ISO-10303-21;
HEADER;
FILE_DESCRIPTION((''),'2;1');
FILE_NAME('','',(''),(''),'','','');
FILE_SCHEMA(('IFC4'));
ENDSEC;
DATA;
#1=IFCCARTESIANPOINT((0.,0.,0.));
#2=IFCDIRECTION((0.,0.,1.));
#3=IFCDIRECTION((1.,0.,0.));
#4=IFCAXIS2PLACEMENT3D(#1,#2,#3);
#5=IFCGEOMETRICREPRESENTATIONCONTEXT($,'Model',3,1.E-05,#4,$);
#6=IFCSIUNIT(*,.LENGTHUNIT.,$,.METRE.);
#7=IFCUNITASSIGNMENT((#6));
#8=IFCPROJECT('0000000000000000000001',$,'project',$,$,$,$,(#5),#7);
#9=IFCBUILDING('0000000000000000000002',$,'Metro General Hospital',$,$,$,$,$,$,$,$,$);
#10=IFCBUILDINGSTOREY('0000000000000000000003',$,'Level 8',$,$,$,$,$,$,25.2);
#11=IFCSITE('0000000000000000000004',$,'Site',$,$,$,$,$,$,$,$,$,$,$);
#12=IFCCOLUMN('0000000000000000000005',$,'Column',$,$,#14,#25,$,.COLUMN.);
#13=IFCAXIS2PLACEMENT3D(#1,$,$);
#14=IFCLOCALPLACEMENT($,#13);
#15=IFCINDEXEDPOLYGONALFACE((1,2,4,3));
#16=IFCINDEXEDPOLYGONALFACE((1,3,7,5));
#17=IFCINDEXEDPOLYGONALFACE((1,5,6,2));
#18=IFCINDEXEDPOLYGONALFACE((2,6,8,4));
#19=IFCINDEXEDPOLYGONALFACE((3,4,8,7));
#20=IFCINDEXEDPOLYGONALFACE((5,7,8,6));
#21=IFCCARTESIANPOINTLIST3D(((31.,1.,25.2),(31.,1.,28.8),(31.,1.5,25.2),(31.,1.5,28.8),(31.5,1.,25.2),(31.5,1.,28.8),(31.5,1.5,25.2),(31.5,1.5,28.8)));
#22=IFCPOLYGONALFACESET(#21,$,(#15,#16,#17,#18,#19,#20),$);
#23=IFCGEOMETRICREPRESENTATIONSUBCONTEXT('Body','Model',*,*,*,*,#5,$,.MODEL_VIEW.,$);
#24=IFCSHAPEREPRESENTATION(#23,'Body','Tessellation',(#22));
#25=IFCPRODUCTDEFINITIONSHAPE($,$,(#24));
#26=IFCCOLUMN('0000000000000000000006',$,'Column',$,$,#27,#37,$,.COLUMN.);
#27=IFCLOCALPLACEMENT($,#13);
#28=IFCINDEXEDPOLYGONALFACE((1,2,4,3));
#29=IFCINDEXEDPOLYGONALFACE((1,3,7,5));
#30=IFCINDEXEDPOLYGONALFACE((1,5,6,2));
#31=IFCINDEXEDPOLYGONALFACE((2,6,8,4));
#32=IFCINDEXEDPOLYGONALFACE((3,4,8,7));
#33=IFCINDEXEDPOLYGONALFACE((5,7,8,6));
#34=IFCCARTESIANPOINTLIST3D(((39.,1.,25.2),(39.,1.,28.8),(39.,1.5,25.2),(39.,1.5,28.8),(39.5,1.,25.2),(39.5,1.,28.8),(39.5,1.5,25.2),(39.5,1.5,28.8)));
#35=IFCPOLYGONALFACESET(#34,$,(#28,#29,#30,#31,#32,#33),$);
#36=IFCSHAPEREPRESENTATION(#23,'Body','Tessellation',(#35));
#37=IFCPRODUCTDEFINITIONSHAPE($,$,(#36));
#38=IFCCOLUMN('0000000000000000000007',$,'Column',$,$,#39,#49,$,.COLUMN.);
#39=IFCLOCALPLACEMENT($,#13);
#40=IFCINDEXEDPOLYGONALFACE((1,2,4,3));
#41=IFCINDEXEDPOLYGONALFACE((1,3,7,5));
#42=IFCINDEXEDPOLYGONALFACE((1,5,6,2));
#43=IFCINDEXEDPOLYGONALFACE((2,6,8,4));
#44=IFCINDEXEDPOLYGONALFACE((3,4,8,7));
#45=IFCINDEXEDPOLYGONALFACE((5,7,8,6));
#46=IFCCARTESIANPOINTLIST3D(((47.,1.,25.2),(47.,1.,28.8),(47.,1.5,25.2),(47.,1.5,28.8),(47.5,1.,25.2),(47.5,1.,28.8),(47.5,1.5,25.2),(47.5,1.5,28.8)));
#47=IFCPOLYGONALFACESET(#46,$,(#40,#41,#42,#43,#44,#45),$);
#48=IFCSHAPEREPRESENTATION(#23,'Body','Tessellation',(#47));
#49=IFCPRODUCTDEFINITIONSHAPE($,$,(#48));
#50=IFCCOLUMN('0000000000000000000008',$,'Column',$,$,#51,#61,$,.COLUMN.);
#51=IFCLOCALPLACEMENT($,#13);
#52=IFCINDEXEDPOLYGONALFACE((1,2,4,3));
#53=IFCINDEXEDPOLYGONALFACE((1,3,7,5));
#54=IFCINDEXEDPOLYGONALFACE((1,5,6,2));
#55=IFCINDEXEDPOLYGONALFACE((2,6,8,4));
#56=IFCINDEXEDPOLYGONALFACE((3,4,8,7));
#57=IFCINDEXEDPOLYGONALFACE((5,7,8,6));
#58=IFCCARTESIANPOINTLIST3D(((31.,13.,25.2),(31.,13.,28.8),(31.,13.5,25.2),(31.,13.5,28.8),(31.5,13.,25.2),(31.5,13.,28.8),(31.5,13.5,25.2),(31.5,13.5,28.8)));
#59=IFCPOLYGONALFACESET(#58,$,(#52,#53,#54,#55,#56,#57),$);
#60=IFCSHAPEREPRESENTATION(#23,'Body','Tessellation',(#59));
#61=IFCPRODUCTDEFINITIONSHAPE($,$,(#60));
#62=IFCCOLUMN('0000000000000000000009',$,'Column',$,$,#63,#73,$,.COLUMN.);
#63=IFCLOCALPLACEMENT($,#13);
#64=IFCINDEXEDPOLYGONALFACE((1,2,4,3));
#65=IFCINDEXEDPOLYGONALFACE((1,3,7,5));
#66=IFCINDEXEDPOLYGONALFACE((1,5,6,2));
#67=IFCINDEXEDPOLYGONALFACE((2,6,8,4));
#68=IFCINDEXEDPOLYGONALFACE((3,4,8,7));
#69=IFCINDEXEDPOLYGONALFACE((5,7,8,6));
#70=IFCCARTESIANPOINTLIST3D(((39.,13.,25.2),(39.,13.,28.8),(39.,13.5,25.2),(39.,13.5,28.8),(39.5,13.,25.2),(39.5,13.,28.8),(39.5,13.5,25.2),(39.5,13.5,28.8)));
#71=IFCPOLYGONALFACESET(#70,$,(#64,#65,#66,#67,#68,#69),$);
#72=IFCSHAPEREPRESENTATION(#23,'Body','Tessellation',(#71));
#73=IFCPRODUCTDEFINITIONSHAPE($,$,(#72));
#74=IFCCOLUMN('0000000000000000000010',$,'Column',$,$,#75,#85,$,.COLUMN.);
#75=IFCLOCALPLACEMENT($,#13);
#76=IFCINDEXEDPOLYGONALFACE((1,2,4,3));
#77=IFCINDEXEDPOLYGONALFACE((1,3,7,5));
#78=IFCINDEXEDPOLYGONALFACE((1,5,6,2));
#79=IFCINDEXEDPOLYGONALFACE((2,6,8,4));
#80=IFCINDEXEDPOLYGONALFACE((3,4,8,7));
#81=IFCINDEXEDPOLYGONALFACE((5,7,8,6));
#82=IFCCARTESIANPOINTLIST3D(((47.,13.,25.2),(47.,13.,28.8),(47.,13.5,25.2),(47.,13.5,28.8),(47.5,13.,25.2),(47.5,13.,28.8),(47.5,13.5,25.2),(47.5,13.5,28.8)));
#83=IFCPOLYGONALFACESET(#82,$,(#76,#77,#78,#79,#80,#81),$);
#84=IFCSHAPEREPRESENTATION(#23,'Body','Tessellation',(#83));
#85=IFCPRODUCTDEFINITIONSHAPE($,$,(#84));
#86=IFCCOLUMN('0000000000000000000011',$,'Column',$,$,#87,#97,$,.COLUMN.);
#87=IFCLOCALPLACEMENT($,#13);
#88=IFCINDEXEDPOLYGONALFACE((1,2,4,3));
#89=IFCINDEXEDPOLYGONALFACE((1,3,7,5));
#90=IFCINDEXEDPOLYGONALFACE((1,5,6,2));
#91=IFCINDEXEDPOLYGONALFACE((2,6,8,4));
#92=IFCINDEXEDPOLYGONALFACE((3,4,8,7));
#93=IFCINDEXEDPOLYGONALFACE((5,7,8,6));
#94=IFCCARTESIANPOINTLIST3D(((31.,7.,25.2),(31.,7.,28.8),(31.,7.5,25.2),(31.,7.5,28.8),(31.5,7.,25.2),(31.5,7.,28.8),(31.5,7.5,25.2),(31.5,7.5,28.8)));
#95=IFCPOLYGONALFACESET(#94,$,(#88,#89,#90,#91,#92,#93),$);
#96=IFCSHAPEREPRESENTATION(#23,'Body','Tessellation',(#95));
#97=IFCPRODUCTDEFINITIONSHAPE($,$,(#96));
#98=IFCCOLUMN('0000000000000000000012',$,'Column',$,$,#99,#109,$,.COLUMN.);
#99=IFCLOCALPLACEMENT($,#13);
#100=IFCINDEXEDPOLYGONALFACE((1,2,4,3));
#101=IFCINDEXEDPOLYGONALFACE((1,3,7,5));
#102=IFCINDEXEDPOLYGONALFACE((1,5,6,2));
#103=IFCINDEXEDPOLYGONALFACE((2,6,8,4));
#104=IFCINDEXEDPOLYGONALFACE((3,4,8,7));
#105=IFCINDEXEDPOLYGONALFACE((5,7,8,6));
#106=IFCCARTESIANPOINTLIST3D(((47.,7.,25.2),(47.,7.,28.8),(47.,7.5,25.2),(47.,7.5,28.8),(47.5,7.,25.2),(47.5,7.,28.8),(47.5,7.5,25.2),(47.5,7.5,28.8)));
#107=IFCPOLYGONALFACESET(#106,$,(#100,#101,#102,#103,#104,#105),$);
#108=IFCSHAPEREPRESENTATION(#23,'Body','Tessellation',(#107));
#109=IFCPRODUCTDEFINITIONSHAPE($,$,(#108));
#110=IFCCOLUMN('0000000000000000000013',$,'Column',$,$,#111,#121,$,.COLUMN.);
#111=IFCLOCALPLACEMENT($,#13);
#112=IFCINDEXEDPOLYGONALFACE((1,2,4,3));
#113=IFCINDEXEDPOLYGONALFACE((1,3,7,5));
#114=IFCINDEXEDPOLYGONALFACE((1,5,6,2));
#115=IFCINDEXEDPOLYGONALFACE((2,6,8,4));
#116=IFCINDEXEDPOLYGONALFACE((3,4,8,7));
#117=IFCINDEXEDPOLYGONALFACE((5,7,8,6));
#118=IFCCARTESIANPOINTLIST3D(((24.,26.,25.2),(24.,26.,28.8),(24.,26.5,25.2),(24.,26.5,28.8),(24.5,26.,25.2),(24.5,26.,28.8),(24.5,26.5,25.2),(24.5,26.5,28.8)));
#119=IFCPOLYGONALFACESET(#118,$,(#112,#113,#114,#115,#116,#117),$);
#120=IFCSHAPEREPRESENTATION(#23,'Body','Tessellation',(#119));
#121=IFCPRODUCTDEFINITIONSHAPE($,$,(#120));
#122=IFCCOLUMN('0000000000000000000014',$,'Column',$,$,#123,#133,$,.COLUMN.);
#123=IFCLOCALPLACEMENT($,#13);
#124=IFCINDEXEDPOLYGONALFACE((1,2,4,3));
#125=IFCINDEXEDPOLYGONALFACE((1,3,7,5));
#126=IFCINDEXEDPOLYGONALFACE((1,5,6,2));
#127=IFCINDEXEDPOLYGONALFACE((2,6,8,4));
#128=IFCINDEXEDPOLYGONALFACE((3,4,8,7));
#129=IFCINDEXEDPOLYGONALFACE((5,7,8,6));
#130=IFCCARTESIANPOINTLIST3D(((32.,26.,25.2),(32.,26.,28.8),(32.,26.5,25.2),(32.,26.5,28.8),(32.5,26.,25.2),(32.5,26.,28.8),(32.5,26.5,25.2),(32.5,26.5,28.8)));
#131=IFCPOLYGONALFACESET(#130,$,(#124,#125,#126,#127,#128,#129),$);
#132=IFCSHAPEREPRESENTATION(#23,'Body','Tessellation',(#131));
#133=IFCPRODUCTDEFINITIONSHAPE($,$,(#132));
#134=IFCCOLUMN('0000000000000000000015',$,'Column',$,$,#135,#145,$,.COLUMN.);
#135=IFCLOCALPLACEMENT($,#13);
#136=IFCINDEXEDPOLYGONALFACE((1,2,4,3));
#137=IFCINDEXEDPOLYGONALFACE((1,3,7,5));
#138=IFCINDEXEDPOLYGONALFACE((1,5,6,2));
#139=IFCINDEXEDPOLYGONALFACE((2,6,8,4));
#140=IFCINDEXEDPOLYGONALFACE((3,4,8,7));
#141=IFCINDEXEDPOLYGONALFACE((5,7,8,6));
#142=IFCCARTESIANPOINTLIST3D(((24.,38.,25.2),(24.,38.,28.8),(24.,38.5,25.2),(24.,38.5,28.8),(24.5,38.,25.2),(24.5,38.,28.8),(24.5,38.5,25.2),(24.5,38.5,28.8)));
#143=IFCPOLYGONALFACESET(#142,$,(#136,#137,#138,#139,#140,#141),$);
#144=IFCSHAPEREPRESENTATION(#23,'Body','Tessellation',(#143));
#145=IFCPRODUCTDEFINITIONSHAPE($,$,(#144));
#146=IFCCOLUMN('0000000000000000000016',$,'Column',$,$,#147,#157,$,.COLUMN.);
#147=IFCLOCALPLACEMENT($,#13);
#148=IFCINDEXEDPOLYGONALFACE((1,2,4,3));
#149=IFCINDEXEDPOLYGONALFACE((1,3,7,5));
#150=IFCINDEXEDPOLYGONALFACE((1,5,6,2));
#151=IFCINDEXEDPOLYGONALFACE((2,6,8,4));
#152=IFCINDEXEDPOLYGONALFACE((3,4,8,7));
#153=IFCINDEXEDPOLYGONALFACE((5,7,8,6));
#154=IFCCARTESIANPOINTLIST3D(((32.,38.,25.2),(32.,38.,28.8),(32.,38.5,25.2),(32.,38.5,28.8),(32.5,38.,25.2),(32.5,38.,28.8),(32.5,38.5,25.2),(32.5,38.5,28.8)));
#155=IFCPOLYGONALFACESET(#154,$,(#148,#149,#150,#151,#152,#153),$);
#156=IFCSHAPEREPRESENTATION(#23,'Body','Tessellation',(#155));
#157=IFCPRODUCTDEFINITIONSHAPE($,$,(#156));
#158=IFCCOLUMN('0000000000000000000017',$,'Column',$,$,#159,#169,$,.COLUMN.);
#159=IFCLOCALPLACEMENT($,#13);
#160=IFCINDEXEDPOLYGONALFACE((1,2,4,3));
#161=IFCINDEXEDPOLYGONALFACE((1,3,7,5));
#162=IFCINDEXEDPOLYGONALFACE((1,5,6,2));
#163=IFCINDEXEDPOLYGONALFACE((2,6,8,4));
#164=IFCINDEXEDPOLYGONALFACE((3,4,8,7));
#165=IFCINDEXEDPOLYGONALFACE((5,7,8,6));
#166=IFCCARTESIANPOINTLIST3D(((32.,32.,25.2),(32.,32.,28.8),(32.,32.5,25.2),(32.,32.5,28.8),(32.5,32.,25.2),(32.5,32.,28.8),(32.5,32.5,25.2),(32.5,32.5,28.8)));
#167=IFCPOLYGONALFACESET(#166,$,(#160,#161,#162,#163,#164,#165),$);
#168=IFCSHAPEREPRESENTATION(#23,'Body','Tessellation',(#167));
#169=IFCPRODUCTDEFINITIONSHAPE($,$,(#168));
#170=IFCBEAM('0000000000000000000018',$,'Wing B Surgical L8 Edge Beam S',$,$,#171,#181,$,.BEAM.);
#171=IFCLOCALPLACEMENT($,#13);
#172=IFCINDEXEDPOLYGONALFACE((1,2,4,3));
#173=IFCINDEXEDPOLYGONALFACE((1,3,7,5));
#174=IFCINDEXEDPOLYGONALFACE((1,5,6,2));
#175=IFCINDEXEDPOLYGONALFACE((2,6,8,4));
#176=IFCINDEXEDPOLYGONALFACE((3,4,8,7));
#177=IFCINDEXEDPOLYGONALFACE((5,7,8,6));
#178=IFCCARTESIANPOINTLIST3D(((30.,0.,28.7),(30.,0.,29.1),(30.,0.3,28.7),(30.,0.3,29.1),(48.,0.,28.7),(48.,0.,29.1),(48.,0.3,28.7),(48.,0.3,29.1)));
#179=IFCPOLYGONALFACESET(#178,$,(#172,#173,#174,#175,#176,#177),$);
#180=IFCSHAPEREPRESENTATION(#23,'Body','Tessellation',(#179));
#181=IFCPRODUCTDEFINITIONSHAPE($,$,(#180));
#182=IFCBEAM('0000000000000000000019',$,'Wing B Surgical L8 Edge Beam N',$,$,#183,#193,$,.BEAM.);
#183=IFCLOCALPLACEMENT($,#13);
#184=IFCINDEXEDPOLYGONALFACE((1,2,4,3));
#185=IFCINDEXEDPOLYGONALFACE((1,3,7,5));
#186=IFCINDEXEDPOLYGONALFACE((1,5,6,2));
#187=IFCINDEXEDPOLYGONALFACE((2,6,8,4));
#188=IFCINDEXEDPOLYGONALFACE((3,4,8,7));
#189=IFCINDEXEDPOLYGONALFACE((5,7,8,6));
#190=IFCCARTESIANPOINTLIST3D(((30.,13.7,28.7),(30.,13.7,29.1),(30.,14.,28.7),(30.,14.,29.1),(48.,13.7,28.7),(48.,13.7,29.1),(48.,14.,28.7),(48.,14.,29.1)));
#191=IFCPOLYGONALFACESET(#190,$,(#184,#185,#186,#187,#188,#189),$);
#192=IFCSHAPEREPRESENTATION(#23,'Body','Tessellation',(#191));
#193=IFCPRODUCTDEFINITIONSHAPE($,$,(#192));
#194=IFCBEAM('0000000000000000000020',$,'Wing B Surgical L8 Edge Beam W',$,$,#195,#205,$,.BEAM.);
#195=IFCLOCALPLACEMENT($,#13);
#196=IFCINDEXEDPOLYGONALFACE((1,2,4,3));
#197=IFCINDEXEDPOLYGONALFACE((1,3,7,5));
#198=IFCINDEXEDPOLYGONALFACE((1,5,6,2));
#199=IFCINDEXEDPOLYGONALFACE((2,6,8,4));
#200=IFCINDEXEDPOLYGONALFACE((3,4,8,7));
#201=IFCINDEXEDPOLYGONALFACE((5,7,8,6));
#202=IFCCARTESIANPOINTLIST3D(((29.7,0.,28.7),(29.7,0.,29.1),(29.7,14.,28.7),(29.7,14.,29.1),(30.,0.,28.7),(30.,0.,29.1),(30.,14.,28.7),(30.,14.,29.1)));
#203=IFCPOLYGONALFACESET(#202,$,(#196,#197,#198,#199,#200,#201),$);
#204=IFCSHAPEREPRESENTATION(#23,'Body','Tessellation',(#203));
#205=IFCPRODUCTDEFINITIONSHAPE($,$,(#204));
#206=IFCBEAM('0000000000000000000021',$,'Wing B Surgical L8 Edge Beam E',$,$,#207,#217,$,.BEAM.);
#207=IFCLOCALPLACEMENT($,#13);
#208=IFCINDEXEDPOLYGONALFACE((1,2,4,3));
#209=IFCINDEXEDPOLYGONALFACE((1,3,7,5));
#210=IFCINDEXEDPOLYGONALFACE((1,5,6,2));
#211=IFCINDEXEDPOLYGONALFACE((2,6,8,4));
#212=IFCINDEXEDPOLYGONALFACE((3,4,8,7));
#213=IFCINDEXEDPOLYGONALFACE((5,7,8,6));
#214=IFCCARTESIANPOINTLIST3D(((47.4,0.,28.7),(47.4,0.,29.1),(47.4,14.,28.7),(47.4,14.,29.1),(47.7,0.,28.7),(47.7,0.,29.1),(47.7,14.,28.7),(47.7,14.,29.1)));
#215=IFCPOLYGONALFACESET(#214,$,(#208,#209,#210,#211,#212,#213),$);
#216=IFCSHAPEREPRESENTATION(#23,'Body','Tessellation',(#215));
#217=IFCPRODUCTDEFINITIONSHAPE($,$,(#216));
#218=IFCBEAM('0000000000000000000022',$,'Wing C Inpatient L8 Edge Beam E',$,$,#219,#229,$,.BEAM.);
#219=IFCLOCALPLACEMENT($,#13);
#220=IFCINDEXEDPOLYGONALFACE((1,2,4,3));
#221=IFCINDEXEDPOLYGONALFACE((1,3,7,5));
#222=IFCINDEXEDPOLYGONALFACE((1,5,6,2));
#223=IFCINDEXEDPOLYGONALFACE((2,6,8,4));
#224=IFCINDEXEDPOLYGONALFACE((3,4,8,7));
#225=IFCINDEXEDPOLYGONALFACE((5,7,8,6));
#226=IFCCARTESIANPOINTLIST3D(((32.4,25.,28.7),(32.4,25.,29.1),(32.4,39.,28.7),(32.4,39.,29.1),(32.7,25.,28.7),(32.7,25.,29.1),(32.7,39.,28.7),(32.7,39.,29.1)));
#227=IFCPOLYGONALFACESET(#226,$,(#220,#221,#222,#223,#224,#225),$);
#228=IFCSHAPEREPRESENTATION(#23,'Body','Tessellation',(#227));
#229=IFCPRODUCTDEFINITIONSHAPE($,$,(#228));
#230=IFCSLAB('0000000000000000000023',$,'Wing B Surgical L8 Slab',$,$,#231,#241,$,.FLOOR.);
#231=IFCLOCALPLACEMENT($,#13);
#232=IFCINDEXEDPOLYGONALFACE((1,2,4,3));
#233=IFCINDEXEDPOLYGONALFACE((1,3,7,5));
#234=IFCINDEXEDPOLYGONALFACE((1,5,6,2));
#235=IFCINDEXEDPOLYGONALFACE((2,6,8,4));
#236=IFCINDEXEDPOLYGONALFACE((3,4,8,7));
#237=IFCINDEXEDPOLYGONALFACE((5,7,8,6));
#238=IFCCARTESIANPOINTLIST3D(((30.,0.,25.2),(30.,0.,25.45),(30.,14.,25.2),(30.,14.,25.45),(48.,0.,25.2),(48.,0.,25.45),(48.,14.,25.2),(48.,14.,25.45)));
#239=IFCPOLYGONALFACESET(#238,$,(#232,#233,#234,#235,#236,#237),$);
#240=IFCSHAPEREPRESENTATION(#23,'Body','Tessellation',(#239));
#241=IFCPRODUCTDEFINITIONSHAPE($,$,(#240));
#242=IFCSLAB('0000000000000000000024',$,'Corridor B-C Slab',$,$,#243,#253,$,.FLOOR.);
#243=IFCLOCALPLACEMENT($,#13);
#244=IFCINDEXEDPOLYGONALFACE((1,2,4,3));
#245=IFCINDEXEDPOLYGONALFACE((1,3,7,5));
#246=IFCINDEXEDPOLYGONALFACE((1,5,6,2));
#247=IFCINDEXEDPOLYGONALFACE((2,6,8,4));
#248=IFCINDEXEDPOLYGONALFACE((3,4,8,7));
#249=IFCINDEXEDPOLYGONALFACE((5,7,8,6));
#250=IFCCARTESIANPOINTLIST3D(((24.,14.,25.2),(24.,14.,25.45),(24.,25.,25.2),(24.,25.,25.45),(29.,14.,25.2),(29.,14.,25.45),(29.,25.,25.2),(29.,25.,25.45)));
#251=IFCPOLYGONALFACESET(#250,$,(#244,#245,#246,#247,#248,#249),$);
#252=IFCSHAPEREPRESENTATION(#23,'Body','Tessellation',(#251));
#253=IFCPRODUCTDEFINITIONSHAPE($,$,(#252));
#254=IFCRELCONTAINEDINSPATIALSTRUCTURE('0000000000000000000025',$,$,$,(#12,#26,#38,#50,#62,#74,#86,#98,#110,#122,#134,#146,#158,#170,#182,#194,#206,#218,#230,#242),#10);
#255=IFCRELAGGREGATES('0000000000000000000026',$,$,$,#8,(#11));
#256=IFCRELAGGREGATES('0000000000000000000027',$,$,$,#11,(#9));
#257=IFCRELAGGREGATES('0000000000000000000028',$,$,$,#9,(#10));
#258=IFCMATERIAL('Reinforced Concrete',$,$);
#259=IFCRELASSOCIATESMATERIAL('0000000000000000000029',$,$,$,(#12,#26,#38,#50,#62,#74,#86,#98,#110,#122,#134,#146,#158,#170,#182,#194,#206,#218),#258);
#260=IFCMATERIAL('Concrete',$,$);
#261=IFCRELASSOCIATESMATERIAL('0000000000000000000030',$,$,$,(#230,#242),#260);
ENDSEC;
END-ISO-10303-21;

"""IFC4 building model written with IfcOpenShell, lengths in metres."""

from ifc_helpers import new_model, si_unit, frame, origin_with_axes, place, context, subcontext, project, spatial, line, indexed_curve, outline, extrude, material, element, save


model = new_model("IFC4")

# Units and contexts
model_context = context("Model", 3, precision=1e-05, world=origin_with_axes())
body_context = subcontext(model_context, "Body", "Model", "MODEL_VIEW")
ifc_project = project(units=[si_unit("LENGTHUNIT", "METRE")], contexts=[model_context])

# Site, building, storey
site = spatial("IfcSite", under=ifc_project, Name="Site")
building = spatial("IfcBuilding", under=site, Name="Metro General Hospital")
storey = spatial("IfcBuildingStorey", under=building, Name="Level 8", Elevation=25.2)

# Columns
ifc_material_1 = material(Name="Reinforced Concrete")
for number, where, z_axis, x_axis, name in (
    (1, (31.0, 1.0, 25.2), (0.0, 0.0, 1.0), (1.0, 0.0, 0.0), "Column"),
    (2, (39.0, 1.0, 25.2), (0.0, 0.0, 1.0), (1.0, 0.0, 0.0), "Column"),
    (3, (47.0, 1.0, 25.2), (0.0, 0.0, 1.0), (1.0, 0.0, 0.0), "Column"),
    (4, (31.0, 13.0, 25.2), (0.0, 0.0, 1.0), (1.0, 0.0, 0.0), "Column"),
    (5, (39.0, 13.0, 25.2), (0.0, 0.0, 1.0), (1.0, 0.0, 0.0), "Column"),
    (6, (47.0, 13.0, 25.2), (0.0, 0.0, 1.0), (1.0, 0.0, 0.0), "Column"),
    (7, (31.0, 7.0, 25.2), (0.0, 0.0, 1.0), (1.0, 0.0, 0.0), "Column"),
    (8, (47.0, 7.0, 25.2), (0.0, 0.0, 1.0), (1.0, 0.0, 0.0), "Column"),
    (9, (24.0, 26.0, 25.2), (0.0, 0.0, 1.0), (1.0, 0.0, 0.0), "Column"),
    (10, (32.0, 26.0, 25.2), (0.0, 0.0, 1.0), (1.0, 0.0, 0.0), "Column"),
    (11, (24.0, 38.0, 25.2), (0.0, 0.0, 1.0), (1.0, 0.0, 0.0), "Column"),
    (12, (32.0, 38.0, 25.2), (0.0, 0.0, 1.0), (1.0, 0.0, 0.0), "Column"),
    (13, (32.0, 32.0, 25.2), (0.0, 0.0, 1.0), (1.0, 0.0, 0.0), "Column"),
):
    element("IfcColumn", number, at=place(None, frame(where, z_axis=z_axis, x_axis=x_axis)), inside=storey, material=ifc_material_1, Name=name, PredefinedType="COLUMN", context=body_context, shape_type="SweptSolid", body=[
        extrude(outline(indexed_curve([(0.0, 0.0), (0.5, 0.0), (0.5, 0.5), (0.0, 0.5)], segments=[line(1, 2, 3, 4, 1)])), origin_with_axes(), (0.0, 0.0, 1.0), 3.6),
    ])

# Beams
for number, where, z_axis, x_axis, name in (
    (14, (30.0, 0.0, 28.7), (0.0, 0.0, 1.0), (1.0, 0.0, 0.0), "Wing B Surgical L8 Edge Beam S"),
    (15, (30.0, 13.7, 28.7), (0.0, 0.0, 1.0), (1.0, 0.0, 0.0), "Wing B Surgical L8 Edge Beam N"),
):
    element("IfcBeam", number, at=place(None, frame(where, z_axis=z_axis, x_axis=x_axis)), inside=storey, material=ifc_material_1, Name=name, PredefinedType="BEAM", context=body_context, shape_type="SweptSolid", body=[
        extrude(outline(indexed_curve([(0.0, 0.0), (18.0, 0.0), (18.0, 0.3), (0.0, 0.3)], segments=[line(1, 2, 3, 4, 1)])), origin_with_axes(), (0.0, 0.0, 1.0), 0.4),
    ])
for number, where, z_axis, x_axis, name in (
    (16, (30.0, 0.0, 28.7), (0.0, 0.0, 1.0), (0.0, 1.0, 0.0), "Wing B Surgical L8 Edge Beam W"),
    (17, (47.7, 0.0, 28.7), (0.0, 0.0, 1.0), (0.0, 1.0, 0.0), "Wing B Surgical L8 Edge Beam E"),
    (18, (32.7, 25.0, 28.7), (0.0, 0.0, 1.0), (0.0, 1.0, 0.0), "Wing C Inpatient L8 Edge Beam E"),
):
    element("IfcBeam", number, at=place(None, frame(where, z_axis=z_axis, x_axis=x_axis)), inside=storey, material=ifc_material_1, Name=name, PredefinedType="BEAM", context=body_context, shape_type="SweptSolid", body=[
        extrude(outline(indexed_curve([(0.0, 0.0), (14.0, 0.0), (14.0, 0.3), (0.0, 0.3)], segments=[line(1, 2, 3, 4, 1)])), origin_with_axes(), (0.0, 0.0, 1.0), 0.4),
    ])

# Slabs
ifc_material_2 = material(Name="Concrete")
slab_1_placement = place(None, frame((30.0, 0.0, 25.2), z_axis=(0.0, 0.0, 1.0), x_axis=(1.0, 0.0, 0.0)))
element("IfcSlab", 19, at=slab_1_placement, inside=storey, material=ifc_material_2, Name="Wing B Surgical L8 Slab", PredefinedType="FLOOR", context=body_context, shape_type="SweptSolid", body=[
    extrude(outline(indexed_curve([(0.0, 0.0), (18.0, 0.0), (18.0, 14.0), (0.0, 14.0)], segments=[line(1, 2, 3, 4, 1)])), origin_with_axes(), (0.0, 0.0, 1.0), 0.25),
])
slab_2_placement = place(None, frame((24.0, 14.0, 25.2), z_axis=(0.0, 0.0, 1.0), x_axis=(1.0, 0.0, 0.0)))
element("IfcSlab", 20, at=slab_2_placement, inside=storey, material=ifc_material_2, Name="Corridor B-C Slab", PredefinedType="FLOOR", context=body_context, shape_type="SweptSolid", body=[
    extrude(outline(indexed_curve([(0.0, 0.0), (5.0, 0.0), (5.0, 11.0), (0.0, 11.0)], segments=[line(1, 2, 3, 4, 1)])), origin_with_axes(), (0.0, 0.0, 1.0), 0.25),
])

save(model, "model.ifc")
